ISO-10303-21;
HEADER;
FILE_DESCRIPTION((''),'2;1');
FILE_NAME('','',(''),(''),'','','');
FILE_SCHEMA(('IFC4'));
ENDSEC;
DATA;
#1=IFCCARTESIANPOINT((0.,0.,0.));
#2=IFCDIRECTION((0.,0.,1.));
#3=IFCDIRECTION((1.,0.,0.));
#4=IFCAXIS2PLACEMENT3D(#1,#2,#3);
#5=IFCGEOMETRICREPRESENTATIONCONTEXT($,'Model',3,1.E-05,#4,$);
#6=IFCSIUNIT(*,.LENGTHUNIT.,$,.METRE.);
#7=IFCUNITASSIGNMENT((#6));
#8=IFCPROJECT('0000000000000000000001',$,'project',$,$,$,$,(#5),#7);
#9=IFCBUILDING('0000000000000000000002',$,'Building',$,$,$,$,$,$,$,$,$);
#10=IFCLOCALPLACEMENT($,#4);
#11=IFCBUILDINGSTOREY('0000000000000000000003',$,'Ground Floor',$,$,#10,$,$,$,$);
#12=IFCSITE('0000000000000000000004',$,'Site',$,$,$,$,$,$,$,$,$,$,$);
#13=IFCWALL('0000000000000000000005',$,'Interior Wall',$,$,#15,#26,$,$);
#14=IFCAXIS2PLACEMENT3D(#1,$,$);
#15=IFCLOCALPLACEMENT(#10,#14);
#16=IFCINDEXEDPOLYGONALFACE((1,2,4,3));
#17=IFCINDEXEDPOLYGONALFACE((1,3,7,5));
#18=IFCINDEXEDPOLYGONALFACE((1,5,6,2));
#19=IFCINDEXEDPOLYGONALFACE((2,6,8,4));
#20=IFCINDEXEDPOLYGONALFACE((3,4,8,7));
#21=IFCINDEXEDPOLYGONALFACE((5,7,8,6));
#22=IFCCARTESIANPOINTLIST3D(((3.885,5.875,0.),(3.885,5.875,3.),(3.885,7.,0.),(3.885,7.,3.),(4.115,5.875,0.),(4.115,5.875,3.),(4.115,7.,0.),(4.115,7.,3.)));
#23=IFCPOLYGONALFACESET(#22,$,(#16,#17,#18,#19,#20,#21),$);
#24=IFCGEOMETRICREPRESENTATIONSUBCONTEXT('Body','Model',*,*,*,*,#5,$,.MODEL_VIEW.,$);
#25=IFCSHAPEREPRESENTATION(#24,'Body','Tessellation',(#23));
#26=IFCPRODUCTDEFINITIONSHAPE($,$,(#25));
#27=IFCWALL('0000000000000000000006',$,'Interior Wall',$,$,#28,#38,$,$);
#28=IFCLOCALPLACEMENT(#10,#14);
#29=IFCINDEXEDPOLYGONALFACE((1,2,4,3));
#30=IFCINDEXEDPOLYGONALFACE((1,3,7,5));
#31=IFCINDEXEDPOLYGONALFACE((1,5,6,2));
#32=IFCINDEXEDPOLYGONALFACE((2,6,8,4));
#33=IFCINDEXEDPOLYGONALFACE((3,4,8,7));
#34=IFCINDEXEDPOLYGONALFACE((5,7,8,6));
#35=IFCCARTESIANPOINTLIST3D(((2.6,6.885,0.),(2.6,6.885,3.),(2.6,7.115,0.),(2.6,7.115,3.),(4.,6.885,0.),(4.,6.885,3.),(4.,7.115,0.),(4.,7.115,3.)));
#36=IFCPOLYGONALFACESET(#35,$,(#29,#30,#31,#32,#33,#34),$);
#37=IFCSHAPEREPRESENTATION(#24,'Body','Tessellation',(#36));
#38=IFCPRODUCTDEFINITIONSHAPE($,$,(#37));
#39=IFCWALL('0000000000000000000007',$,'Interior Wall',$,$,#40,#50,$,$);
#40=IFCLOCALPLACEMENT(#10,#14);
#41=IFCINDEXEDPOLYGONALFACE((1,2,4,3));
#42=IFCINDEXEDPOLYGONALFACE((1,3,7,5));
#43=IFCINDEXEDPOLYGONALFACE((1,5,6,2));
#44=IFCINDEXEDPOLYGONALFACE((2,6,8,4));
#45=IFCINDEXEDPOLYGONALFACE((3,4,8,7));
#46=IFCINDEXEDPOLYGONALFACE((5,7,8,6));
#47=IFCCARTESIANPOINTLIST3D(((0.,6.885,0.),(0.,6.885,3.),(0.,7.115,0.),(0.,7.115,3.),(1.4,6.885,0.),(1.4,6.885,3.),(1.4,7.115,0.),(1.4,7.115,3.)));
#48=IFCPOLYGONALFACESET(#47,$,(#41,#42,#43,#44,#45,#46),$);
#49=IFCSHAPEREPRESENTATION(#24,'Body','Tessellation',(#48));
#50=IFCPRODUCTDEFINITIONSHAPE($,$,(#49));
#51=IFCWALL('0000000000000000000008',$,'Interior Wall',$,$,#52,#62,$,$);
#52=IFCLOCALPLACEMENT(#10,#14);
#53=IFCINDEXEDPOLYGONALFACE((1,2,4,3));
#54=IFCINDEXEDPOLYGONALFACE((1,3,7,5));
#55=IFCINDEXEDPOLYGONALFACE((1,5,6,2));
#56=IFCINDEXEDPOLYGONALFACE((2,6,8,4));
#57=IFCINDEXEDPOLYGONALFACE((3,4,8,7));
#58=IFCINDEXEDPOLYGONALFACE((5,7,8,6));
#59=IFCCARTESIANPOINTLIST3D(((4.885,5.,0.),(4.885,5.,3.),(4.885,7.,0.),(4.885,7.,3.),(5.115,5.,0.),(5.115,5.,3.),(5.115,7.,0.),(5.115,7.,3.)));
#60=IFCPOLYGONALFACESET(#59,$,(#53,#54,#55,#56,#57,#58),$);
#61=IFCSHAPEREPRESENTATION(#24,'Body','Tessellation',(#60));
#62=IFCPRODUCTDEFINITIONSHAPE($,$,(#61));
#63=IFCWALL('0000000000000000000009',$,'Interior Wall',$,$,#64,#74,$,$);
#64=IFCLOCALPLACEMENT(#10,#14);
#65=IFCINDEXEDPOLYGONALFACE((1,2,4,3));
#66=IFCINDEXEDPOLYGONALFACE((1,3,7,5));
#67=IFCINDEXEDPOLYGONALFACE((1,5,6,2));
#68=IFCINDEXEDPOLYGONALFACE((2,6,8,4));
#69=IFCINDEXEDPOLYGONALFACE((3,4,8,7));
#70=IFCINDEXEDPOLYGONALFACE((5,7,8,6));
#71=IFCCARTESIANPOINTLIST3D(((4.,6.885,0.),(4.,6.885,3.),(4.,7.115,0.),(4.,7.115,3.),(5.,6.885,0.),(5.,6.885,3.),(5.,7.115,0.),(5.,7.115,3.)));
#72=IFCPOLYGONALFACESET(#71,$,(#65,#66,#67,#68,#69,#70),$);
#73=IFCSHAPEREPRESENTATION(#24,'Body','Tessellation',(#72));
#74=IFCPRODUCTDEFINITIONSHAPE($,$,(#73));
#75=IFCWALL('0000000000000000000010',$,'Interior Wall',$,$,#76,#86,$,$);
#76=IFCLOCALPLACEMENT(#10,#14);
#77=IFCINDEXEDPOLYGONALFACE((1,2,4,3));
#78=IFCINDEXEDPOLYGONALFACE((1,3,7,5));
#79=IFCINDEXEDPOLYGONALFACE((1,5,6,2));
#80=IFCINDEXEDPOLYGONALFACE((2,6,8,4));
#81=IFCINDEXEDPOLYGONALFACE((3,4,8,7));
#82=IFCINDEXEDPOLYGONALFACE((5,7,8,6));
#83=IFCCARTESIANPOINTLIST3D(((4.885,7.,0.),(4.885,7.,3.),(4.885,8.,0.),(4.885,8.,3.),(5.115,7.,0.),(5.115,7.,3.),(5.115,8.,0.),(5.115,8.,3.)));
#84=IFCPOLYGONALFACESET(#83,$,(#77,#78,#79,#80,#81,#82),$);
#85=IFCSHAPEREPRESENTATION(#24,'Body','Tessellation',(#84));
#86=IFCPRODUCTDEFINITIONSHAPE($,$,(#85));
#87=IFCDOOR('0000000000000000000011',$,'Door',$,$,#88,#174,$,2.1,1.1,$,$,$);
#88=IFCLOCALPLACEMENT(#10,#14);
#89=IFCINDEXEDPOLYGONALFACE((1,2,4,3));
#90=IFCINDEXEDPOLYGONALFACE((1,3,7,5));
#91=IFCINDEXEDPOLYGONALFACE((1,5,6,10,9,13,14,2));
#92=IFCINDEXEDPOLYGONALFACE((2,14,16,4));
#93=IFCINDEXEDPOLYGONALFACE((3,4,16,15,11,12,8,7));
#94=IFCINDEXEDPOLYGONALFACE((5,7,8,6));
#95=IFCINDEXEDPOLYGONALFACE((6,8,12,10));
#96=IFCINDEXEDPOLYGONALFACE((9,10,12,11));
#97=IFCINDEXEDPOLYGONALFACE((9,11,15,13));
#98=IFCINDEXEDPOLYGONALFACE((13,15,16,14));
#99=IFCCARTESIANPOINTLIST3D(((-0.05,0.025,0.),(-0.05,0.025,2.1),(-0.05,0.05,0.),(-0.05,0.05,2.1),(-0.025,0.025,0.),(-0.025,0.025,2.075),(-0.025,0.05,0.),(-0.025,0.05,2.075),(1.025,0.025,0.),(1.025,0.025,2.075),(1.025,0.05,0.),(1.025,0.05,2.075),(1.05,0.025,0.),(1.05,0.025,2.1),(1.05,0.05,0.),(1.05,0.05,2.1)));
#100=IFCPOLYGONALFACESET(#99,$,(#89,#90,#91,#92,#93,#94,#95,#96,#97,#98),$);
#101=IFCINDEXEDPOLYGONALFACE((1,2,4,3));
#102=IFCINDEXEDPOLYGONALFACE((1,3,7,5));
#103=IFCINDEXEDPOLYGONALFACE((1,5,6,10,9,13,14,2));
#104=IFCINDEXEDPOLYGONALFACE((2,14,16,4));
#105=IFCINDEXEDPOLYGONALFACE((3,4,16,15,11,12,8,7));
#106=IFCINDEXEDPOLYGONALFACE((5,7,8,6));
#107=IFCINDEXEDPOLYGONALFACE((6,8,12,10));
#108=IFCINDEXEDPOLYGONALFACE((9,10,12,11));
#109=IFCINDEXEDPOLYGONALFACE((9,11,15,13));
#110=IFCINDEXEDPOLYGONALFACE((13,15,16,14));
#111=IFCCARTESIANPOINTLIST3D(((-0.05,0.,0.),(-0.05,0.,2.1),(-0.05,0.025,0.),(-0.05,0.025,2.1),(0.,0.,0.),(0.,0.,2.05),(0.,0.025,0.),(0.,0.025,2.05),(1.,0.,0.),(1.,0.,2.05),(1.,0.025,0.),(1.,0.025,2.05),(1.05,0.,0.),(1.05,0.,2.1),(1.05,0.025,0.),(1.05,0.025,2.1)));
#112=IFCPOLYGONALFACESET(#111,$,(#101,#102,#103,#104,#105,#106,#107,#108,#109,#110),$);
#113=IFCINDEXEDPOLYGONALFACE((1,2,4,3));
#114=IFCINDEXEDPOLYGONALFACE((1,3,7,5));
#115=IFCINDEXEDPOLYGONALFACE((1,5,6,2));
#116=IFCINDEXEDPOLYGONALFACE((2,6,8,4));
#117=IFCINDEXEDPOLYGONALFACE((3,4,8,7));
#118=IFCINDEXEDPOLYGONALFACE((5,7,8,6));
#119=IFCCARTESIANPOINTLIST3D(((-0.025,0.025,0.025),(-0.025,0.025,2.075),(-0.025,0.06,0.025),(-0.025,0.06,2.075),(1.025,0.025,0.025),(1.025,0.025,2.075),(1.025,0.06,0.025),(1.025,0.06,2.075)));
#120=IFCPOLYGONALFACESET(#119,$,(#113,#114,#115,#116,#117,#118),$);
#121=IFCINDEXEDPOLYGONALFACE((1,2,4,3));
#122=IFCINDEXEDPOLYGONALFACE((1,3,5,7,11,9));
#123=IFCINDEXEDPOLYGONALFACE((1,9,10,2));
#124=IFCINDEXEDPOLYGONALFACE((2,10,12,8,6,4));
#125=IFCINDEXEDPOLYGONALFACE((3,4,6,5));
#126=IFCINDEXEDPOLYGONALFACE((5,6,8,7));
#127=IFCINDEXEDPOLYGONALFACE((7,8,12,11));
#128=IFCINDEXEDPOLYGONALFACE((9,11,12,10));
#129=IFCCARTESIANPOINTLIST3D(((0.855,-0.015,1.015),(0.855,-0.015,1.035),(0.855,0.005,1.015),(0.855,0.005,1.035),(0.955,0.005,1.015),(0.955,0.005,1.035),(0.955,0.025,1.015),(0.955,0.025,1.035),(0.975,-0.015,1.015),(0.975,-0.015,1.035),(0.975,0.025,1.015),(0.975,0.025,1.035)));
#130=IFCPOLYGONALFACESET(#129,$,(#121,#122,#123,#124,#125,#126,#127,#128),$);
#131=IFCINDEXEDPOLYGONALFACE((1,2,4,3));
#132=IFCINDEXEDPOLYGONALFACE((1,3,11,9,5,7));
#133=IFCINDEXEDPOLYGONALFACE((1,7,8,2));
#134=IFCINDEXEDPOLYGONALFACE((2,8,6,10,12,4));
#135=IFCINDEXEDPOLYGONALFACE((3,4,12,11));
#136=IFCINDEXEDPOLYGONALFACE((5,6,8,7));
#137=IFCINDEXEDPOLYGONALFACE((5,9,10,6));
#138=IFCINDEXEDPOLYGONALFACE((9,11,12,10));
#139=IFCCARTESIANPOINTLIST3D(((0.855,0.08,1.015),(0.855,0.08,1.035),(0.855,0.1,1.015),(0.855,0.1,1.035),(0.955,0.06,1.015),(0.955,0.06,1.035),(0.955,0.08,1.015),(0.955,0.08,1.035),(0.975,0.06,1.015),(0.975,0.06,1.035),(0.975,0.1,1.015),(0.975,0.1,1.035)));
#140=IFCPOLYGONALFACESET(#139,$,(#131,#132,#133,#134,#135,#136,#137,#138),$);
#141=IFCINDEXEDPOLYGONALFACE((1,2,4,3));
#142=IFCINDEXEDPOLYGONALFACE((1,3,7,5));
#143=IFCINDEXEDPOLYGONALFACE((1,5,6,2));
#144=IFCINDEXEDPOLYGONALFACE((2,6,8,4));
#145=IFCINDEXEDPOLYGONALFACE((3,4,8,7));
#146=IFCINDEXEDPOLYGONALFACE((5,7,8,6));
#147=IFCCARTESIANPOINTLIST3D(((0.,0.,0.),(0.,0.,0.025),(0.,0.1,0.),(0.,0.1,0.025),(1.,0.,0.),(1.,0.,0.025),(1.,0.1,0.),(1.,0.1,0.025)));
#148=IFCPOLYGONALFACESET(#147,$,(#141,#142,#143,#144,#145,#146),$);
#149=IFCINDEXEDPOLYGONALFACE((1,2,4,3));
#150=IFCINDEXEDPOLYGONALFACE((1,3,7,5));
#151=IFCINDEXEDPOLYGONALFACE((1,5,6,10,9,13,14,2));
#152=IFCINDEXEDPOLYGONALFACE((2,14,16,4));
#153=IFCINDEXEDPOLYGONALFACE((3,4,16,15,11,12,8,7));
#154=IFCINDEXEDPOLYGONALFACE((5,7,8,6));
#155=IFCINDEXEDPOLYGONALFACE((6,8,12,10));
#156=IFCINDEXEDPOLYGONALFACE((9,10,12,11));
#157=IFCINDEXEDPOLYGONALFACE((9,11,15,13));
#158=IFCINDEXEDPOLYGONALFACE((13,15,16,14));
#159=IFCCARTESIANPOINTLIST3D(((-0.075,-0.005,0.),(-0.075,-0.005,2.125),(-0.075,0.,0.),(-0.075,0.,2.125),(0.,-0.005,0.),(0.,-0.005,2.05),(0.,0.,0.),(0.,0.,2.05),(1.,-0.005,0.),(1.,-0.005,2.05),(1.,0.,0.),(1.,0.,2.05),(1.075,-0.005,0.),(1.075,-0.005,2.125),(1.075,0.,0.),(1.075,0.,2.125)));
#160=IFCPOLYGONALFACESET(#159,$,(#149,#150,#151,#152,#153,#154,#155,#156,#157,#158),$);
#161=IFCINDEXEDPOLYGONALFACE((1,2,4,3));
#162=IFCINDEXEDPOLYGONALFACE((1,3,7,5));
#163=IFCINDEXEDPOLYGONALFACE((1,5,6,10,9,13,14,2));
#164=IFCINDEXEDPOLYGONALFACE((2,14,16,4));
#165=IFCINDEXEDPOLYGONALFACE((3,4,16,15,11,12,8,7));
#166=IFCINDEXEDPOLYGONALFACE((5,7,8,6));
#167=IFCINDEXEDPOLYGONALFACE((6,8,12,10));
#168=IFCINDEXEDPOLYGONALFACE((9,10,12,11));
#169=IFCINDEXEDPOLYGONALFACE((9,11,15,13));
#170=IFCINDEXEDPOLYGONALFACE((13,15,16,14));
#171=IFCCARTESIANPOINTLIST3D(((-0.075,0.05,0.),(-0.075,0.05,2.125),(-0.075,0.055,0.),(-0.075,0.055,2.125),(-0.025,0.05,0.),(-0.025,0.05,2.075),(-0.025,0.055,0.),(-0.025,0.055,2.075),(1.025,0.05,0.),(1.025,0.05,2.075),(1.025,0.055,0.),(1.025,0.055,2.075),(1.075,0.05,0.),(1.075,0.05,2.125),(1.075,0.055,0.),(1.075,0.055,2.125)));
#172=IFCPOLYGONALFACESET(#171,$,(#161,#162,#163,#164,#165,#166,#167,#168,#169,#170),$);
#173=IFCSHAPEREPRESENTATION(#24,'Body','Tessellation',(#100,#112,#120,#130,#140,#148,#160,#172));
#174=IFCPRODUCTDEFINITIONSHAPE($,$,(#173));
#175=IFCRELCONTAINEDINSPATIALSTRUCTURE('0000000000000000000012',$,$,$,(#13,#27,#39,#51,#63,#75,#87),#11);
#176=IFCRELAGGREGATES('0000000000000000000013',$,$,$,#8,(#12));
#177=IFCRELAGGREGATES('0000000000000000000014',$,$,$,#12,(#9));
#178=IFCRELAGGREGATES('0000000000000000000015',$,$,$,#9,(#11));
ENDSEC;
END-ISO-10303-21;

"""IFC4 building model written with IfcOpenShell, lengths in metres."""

from ifc_helpers import new_model, si_unit, frame, origin_with_axes, place, context, subcontext, project, spatial, line, indexed_curve, outline, extrude, element, save


model = new_model("IFC4")

# Units and contexts
model_context = context("Model", 3, precision=1e-05, world=origin_with_axes())
body_context = subcontext(model_context, "Body", "Model", "MODEL_VIEW")
ifc_project = project(units=[si_unit("LENGTHUNIT", "METRE")], contexts=[model_context])

# Site, building, storey
site = spatial("IfcSite", under=ifc_project, Name="Site")
building = spatial("IfcBuilding", under=site, Name="Building")
storey_placement = place(None, origin_with_axes())
storey = spatial("IfcBuildingStorey", under=building, at=storey_placement, Name="Ground Floor")

# Walls
for number, where, z_axis, x_axis, name in (
    (1, (4.0, 5.875, 0.0), (0.0, 0.0, 1.0), (0.0, 1.0, 0.0), "Interior Wall"),
):
    element("IfcWall", number, at=place(storey_placement, frame(where, z_axis=z_axis, x_axis=x_axis)), inside=storey, Name=name, context=body_context, shape_type="SweptSolid", body=[
        extrude(outline(indexed_curve([(0.0, 0.0), (0.0, 0.23), (1.125, 0.23), (1.125, 0.0), (0.0, 0.0)], self_intersect=False)), frame((0.0, -0.115, 0.0), z_axis=(0.0, 0.0, 1.0), x_axis=(1.0, 0.0, 0.0)), (0.0, 0.0, 1.0), 3.0),
    ])
for number, where, z_axis, x_axis, name in (
    (2, (4.0, 7.0, 0.0), (0.0, 0.0, 1.0), (-1.0, 0.0, 0.0), "Interior Wall"),
    (3, (1.4, 7.0, 0.0), (0.0, 0.0, 1.0), (-1.0, 0.0, 0.0), "Interior Wall"),
):
    element("IfcWall", number, at=place(storey_placement, frame(where, z_axis=z_axis, x_axis=x_axis)), inside=storey, Name=name, context=body_context, shape_type="SweptSolid", body=[
        extrude(outline(indexed_curve([(0.0, 0.0), (0.0, 0.23), (1.4, 0.23), (1.4, 0.0), (0.0, 0.0)], self_intersect=False)), frame((0.0, -0.115, 0.0), z_axis=(0.0, 0.0, 1.0), x_axis=(1.0, 0.0, 0.0)), (0.0, 0.0, 1.0), 3.0),
    ])
wall_1_placement = place(storey_placement, frame((5.0, 5.0, 0.0), z_axis=(0.0, 0.0, 1.0), x_axis=(0.0, 1.0, 0.0)))
element("IfcWall", 4, at=wall_1_placement, inside=storey, Name="Interior Wall", context=body_context, shape_type="SweptSolid", body=[
    extrude(outline(indexed_curve([(0.0, 0.0), (0.0, 0.23), (2.0, 0.23), (2.0, 0.0), (0.0, 0.0)], self_intersect=False)), frame((0.0, -0.115, 0.0), z_axis=(0.0, 0.0, 1.0), x_axis=(1.0, 0.0, 0.0)), (0.0, 0.0, 1.0), 3.0),
])
for number, where, z_axis, x_axis, name in (
    (5, (5.0, 7.0, 0.0), (0.0, 0.0, 1.0), (-1.0, 0.0, 0.0), "Interior Wall"),
    (6, (5.0, 8.0, 0.0), (0.0, 0.0, 1.0), (0.0, -1.0, 0.0), "Interior Wall"),
):
    element("IfcWall", number, at=place(storey_placement, frame(where, z_axis=z_axis, x_axis=x_axis)), inside=storey, Name=name, context=body_context, shape_type="SweptSolid", body=[
        extrude(outline(indexed_curve([(0.0, 0.0), (0.0, 0.23), (1.0, 0.23), (1.0, 0.0), (0.0, 0.0)], self_intersect=False)), frame((0.0, -0.115, 0.0), z_axis=(0.0, 0.0, 1.0), x_axis=(1.0, 0.0, 0.0)), (0.0, 0.0, 1.0), 3.0),
    ])

# Door
door_1_placement = place(storey_placement, frame((-0.05, 0.0, 0.0), z_axis=(0.0, 0.0, 1.0), x_axis=(1.0, 0.0, 0.0)))
element("IfcDoor", 7, at=door_1_placement, inside=storey, Name="Door", OverallHeight=2.1, OverallWidth=1.1, context=body_context, shape_type="SweptSolid", body=[
    extrude(outline(indexed_curve([(0.0, 0.0), (0.0, 2.1), (1.1, 2.1), (1.1, 0.0), (1.075, 0.0), (1.075, 2.075), (0.025, 2.075), (0.025, 0.0)], segments=[line(1, 2, 3, 4, 5, 6, 7, 8, 1)])), frame((0.0, 0.025, 0.0), z_axis=(0.0, -1.0, 0.0), x_axis=(1.0, 0.0, 0.0)), (0.0, 0.0, -1.0), 0.025),
    extrude(outline(indexed_curve([(0.0, 0.0), (0.0, 2.1), (1.1, 2.1), (1.1, 0.0), (1.05, 0.0), (1.05, 2.05), (0.05, 2.05), (0.05, 0.0)], segments=[line(1, 2, 3, 4, 5, 6, 7, 8, 1)])), frame((0.0, 0.0, 0.0), z_axis=(0.0, -1.0, 0.0), x_axis=(1.0, 0.0, 0.0)), (0.0, 0.0, -1.0), 0.025),
    extrude(outline(indexed_curve([(0.0, 0.0), (1.05, 0.0), (1.05, 0.035), (0.0, 0.035)], segments=[line(1, 2, 3, 4, 1)])), frame((0.025, 0.025, 0.025), z_axis=(0.0, 0.0, 1.0), x_axis=(1.0, 0.0, 0.0)), (0.0, 0.0, 1.0), 2.05),
    extrude(outline(indexed_curve([(0.0, 0.0), (0.0, -0.04), (-0.12, -0.04), (-0.12, -0.02), (-0.02, -0.02), (-0.02, 0.0)], segments=[line(1, 2, 3, 4, 5, 6, 1)])), frame((1.025, 0.025, 1.015), z_axis=(0.0, 0.0, 1.0), x_axis=(1.0, 0.0, 0.0)), (0.0, 0.0, 1.0), 0.02),
    extrude(outline(indexed_curve([(0.0, 0.0), (0.0, 0.04), (-0.12, 0.04), (-0.12, 0.02), (-0.02, 0.02), (-0.02, 0.0)], segments=[line(1, 2, 3, 4, 5, 6, 1)])), frame((1.025, 0.06, 1.015), z_axis=(0.0, 0.0, 1.0), x_axis=(1.0, 0.0, 0.0)), (0.0, 0.0, 1.0), 0.02),
    extrude(outline(indexed_curve([(0.0, 0.0), (1.0, 0.0), (1.0, 0.1), (0.0, 0.1)], segments=[line(1, 2, 3, 4, 1)])), frame((0.05, 0.0, 0.0), z_axis=(0.0, 0.0, 1.0), x_axis=(1.0, 0.0, 0.0)), (0.0, 0.0, 1.0), 0.025),
    extrude(outline(indexed_curve([(0.0, 0.0), (0.0, 2.125), (1.15, 2.125), (1.15, 0.0), (1.075, 0.0), (1.075, 2.05), (0.075, 2.05), (0.075, 0.0)], segments=[line(1, 2, 3, 4, 5, 6, 7, 8, 1)])), frame((-0.025, -0.005, 0.0), z_axis=(0.0, -1.0, 0.0), x_axis=(1.0, 0.0, 0.0)), (0.0, 0.0, -1.0), 0.005),
    extrude(outline(indexed_curve([(0.0, 0.0), (0.0, 2.125), (1.15, 2.125), (1.15, 0.0), (1.1, 0.0), (1.1, 2.075), (0.05, 2.075), (0.05, 0.0)], segments=[line(1, 2, 3, 4, 5, 6, 7, 8, 1)])), frame((-0.025, 0.05, 0.0), z_axis=(0.0, -1.0, 0.0), x_axis=(1.0, 0.0, 0.0)), (0.0, 0.0, -1.0), 0.005),
])

save(model, "model.ifc")
